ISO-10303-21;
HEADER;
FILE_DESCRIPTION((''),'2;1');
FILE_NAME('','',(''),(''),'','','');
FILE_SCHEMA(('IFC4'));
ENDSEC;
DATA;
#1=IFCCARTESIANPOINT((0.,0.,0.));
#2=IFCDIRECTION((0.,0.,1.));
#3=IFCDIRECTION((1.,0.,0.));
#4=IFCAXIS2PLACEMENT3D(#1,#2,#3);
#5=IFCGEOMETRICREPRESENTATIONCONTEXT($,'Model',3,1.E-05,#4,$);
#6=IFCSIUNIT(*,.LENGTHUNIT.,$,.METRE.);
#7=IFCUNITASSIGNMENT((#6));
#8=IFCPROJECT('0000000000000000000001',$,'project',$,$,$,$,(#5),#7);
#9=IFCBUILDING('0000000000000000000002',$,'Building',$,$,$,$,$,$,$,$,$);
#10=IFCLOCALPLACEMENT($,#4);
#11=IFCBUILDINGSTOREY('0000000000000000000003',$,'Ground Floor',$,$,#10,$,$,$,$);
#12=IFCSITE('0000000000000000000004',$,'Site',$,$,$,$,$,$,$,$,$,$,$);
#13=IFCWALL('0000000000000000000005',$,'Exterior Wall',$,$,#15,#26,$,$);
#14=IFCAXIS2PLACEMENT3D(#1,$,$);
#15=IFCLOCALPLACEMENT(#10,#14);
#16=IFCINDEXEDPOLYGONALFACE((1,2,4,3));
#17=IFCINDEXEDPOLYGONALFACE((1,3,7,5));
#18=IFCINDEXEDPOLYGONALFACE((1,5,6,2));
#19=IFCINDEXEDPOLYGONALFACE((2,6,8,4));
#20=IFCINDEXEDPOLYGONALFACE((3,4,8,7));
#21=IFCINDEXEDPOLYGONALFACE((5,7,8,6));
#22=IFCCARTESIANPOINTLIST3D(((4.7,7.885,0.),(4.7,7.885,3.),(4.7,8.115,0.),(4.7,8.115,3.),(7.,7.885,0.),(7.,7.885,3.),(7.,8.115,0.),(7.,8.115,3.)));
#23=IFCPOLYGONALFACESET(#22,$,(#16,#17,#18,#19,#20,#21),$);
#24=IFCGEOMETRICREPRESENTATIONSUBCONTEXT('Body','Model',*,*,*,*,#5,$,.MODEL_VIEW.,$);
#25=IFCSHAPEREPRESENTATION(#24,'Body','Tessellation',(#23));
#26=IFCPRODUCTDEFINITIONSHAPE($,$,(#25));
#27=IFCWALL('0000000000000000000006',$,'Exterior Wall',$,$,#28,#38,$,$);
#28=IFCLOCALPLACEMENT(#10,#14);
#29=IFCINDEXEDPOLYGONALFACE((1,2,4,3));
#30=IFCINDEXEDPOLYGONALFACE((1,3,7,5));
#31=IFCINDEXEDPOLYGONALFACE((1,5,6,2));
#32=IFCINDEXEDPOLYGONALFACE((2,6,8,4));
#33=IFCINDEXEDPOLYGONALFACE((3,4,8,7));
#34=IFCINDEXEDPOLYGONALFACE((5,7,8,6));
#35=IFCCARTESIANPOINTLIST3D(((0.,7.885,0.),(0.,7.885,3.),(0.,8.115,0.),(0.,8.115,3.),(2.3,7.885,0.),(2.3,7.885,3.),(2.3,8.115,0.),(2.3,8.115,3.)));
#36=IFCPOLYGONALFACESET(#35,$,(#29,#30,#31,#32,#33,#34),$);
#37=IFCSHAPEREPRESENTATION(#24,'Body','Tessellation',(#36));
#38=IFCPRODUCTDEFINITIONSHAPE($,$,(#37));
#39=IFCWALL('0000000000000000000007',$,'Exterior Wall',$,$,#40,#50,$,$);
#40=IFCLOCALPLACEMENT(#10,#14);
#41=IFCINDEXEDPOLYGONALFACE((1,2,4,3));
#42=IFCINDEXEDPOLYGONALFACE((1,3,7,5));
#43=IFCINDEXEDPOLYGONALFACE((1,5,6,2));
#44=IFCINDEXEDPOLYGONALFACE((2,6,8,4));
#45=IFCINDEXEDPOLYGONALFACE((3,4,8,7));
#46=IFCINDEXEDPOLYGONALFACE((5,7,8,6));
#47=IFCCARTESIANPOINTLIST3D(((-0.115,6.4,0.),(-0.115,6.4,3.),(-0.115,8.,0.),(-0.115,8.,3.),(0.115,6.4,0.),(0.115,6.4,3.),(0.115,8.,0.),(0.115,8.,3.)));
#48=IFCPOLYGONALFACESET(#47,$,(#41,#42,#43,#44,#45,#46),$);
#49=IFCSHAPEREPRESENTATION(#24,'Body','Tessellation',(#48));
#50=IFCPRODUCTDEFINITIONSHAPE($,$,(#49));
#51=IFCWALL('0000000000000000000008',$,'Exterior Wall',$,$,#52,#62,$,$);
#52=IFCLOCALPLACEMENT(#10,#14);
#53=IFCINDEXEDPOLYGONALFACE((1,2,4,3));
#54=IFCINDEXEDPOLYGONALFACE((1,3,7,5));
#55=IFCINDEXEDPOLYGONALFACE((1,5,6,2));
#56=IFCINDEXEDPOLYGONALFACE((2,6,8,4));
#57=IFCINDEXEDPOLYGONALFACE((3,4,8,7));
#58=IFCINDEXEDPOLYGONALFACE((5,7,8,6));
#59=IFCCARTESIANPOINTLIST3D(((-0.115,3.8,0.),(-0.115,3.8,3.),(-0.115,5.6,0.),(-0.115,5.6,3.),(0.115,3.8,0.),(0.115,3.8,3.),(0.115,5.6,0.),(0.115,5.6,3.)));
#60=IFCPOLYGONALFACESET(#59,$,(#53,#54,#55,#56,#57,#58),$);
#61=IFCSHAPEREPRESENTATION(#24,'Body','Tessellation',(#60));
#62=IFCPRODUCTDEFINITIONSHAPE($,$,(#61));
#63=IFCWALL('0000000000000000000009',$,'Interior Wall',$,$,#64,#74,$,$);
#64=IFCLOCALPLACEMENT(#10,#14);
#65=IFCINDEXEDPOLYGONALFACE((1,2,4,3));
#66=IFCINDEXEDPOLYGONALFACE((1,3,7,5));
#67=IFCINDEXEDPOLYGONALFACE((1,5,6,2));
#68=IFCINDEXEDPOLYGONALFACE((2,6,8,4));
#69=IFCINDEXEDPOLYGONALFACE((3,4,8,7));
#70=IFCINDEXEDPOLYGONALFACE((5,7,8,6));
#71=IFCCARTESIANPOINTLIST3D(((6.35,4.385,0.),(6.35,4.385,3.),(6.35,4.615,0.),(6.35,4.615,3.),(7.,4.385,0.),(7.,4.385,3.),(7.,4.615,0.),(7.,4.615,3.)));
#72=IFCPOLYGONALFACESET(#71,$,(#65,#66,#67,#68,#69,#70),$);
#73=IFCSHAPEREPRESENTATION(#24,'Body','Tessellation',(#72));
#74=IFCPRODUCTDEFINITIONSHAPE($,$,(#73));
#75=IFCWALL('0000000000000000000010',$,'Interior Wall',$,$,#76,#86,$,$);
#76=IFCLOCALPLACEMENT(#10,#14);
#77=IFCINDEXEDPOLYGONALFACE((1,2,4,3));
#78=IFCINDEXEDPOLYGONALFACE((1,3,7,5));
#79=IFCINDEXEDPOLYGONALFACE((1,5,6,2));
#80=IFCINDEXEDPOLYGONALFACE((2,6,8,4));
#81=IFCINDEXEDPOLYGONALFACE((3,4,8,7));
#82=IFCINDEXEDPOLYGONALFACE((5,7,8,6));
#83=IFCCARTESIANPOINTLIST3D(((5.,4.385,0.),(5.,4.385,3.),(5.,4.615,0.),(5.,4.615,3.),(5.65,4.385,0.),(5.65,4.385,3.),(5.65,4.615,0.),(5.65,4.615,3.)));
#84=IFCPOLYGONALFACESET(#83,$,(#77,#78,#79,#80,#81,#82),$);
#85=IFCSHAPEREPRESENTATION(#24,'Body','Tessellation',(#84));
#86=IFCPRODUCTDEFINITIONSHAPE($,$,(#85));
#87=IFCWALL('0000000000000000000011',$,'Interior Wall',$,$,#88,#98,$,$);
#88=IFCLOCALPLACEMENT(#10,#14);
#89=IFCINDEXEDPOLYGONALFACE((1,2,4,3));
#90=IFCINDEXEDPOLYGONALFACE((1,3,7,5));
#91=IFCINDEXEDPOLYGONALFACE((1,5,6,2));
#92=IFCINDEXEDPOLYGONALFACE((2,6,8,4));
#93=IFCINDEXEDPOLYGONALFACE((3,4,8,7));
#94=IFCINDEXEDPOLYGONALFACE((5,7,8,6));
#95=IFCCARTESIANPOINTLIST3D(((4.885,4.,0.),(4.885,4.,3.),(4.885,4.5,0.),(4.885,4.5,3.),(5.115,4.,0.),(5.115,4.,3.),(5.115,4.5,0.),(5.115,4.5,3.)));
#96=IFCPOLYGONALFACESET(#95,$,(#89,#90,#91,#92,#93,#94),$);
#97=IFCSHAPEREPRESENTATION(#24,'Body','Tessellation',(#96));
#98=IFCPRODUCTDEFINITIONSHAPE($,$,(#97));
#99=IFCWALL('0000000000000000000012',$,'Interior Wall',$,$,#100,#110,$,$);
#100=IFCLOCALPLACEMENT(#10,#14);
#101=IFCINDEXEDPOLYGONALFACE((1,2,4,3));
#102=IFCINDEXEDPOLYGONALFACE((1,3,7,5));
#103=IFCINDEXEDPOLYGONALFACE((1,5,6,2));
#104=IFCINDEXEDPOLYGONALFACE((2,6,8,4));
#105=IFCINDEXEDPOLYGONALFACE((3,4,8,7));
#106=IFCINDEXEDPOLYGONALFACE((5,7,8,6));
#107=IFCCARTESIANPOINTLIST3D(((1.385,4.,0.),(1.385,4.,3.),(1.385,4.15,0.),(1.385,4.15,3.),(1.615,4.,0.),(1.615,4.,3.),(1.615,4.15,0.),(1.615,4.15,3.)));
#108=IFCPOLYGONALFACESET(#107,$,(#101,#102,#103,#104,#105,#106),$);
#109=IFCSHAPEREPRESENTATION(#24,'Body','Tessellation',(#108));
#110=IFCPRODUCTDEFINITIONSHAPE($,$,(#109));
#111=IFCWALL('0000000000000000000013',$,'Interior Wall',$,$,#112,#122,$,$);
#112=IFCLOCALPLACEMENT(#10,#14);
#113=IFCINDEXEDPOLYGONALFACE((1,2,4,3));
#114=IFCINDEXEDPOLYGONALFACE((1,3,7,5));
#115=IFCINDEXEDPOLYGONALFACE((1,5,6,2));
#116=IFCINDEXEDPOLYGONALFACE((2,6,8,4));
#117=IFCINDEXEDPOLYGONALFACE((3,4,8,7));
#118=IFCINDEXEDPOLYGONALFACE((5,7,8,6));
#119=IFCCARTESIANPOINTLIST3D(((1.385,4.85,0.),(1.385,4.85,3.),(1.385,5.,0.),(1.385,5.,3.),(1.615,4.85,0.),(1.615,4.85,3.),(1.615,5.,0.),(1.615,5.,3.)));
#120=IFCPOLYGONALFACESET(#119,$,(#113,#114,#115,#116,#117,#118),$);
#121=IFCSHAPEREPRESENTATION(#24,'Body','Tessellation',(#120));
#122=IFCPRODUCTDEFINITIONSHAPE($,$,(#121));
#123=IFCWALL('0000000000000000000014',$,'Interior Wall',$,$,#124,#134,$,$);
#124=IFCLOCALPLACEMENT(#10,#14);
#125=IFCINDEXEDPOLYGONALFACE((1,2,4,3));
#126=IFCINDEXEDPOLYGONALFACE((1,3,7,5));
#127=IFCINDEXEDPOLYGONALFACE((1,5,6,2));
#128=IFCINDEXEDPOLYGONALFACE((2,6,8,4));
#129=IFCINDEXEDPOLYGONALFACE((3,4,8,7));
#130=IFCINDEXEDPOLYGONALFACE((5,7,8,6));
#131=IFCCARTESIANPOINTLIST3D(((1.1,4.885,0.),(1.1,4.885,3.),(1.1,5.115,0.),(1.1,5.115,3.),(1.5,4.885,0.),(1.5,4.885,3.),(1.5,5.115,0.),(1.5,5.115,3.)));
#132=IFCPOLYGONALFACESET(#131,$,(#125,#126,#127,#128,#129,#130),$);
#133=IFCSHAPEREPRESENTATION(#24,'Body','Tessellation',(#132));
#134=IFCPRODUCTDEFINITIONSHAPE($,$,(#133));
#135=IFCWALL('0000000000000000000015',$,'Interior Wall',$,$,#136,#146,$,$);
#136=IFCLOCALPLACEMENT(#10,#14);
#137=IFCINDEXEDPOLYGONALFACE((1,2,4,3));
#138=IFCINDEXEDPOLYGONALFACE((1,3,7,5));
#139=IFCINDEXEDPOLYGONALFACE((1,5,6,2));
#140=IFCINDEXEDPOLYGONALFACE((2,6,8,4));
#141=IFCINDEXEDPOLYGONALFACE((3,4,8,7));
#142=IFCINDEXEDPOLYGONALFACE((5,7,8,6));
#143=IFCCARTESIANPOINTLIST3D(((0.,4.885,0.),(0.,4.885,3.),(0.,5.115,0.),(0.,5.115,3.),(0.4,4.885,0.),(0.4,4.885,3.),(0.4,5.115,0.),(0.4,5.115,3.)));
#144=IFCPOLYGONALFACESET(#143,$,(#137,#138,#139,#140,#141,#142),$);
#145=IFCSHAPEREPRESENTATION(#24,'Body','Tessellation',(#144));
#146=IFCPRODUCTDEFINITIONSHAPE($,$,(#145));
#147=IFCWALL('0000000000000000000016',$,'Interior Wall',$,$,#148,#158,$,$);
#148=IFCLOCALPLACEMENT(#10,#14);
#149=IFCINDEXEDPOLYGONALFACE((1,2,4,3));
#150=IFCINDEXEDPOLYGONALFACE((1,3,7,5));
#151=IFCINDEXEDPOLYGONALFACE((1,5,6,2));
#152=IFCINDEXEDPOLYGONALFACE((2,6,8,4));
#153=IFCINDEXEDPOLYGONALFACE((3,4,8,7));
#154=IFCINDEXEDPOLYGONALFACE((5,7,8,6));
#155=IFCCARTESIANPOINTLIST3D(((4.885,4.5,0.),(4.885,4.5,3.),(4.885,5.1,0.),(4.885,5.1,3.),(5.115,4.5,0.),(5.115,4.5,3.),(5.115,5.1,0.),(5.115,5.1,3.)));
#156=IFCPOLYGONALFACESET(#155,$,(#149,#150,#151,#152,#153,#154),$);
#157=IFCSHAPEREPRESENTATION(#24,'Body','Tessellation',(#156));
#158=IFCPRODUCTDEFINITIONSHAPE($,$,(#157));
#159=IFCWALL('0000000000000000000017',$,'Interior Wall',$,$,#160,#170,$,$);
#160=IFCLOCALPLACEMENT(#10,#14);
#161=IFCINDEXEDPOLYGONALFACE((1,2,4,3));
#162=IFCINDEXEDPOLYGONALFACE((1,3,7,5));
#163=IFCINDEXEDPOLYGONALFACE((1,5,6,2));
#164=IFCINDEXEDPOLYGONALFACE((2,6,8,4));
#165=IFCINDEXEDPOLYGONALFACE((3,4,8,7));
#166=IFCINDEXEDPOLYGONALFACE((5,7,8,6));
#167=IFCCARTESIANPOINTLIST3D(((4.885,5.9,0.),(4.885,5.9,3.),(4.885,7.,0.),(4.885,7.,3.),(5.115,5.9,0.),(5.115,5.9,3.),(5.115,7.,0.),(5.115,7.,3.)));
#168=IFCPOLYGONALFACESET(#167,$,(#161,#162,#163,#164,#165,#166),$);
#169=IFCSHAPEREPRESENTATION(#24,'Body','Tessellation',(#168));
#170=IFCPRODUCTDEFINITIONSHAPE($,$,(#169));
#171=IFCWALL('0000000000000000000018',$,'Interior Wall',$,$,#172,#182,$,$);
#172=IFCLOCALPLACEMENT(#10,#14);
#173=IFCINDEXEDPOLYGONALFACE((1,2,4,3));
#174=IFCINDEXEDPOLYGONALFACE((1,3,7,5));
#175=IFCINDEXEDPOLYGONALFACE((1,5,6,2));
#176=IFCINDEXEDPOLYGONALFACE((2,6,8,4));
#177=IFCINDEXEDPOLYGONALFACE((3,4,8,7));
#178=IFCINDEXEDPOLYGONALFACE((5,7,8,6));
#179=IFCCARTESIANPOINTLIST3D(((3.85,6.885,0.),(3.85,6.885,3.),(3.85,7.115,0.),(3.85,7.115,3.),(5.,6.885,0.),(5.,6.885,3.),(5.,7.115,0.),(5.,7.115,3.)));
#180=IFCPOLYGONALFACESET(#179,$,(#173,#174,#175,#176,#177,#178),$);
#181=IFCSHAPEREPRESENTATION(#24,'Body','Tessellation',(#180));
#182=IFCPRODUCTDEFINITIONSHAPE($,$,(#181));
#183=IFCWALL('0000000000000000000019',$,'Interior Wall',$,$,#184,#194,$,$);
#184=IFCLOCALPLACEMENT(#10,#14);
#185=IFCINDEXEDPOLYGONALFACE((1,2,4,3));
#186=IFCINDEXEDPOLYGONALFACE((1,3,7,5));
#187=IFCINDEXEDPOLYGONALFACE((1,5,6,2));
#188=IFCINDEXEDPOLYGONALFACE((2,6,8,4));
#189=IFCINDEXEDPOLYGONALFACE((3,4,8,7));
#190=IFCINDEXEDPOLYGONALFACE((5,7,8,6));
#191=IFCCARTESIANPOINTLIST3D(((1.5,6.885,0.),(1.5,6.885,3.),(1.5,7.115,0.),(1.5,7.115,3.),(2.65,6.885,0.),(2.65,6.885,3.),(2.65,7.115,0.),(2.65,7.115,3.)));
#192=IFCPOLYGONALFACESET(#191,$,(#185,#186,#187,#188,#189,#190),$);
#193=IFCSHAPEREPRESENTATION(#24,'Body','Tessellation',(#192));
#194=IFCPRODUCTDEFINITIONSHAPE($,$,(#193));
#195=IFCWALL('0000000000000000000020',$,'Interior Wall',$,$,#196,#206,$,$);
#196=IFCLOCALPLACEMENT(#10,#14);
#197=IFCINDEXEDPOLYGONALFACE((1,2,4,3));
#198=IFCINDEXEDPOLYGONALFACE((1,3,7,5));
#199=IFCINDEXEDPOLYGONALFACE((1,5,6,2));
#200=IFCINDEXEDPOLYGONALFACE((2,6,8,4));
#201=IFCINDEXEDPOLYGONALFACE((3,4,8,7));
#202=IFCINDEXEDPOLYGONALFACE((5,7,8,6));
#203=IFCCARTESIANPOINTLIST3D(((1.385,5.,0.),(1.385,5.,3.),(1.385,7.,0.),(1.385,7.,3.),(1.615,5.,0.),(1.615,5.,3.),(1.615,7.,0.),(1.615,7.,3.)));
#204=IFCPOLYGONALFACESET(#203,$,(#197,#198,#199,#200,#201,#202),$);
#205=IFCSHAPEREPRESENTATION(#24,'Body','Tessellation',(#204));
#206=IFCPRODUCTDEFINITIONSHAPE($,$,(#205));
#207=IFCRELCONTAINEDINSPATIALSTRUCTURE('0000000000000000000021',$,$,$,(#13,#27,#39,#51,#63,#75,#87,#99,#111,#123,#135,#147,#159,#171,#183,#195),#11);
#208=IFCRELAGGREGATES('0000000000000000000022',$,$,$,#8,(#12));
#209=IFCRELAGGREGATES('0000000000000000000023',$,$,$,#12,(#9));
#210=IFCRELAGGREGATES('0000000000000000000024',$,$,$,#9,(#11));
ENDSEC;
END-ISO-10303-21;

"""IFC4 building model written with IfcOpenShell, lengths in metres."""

from ifc_helpers import new_model, si_unit, frame, origin_with_axes, place, context, subcontext, project, spatial, indexed_curve, outline, extrude, element, save


model = new_model("IFC4")

# Units and contexts
model_context = context("Model", 3, precision=1e-05, world=origin_with_axes())
body_context = subcontext(model_context, "Body", "Model", "MODEL_VIEW")
ifc_project = project(units=[si_unit("LENGTHUNIT", "METRE")], contexts=[model_context])

# Site, building, storey
site = spatial("IfcSite", under=ifc_project, Name="Site")
building = spatial("IfcBuilding", under=site, Name="Building")
storey_placement = place(None, origin_with_axes())
storey = spatial("IfcBuildingStorey", under=building, at=storey_placement, Name="Ground Floor")

# Walls
for number, where, z_axis, x_axis, name in (
    (1, (7.0, 8.0, 0.0), (0.0, 0.0, 1.0), (-1.0, 0.0, 0.0), "Exterior Wall"),
    (2, (2.3, 8.0, 0.0), (0.0, 0.0, 1.0), (-1.0, 0.0, 0.0), "Exterior Wall"),
):
    element("IfcWall", number, at=place(storey_placement, frame(where, z_axis=z_axis, x_axis=x_axis)), inside=storey, Name=name, context=body_context, shape_type="SweptSolid", body=[
        extrude(outline(indexed_curve([(0.0, 0.0), (0.0, 0.23), (2.3, 0.23), (2.3, 0.0), (0.0, 0.0)], self_intersect=False)), frame((0.0, -0.115, 0.0), z_axis=(0.0, 0.0, 1.0), x_axis=(1.0, 0.0, 0.0)), (0.0, 0.0, 1.0), 3.0),
    ])
wall_1_placement = place(storey_placement, frame((0.0, 8.0, 0.0), z_axis=(0.0, 0.0, 1.0), x_axis=(0.0, -1.0, 0.0)))
element("IfcWall", 3, at=wall_1_placement, inside=storey, Name="Exterior Wall", context=body_context, shape_type="SweptSolid", body=[
    extrude(outline(indexed_curve([(0.0, 0.0), (0.0, 0.23), (1.6, 0.23), (1.6, 0.0), (0.0, 0.0)], self_intersect=False)), frame((0.0, -0.115, 0.0), z_axis=(0.0, 0.0, 1.0), x_axis=(1.0, 0.0, 0.0)), (0.0, 0.0, 1.0), 3.0),
])
wall_2_placement = place(storey_placement, frame((0.0, 5.6, 0.0), z_axis=(0.0, 0.0, 1.0), x_axis=(0.0, -1.0, 0.0)))
element("IfcWall", 4, at=wall_2_placement, inside=storey, Name="Exterior Wall", context=body_context, shape_type="SweptSolid", body=[
    extrude(outline(indexed_curve([(0.0, 0.0), (0.0, 0.23), (1.8, 0.23), (1.8, 0.0), (0.0, 0.0)], self_intersect=False)), frame((0.0, -0.115, 0.0), z_axis=(0.0, 0.0, 1.0), x_axis=(1.0, 0.0, 0.0)), (0.0, 0.0, 1.0), 3.0),
])
for number, where, z_axis, x_axis, name in (
    (5, (7.0, 4.5, 0.0), (0.0, 0.0, 1.0), (-1.0, 0.0, 0.0), "Interior Wall"),
    (6, (5.65, 4.5, 0.0), (0.0, 0.0, 1.0), (-1.0, 0.0, 0.0), "Interior Wall"),
):
    element("IfcWall", number, at=place(storey_placement, frame(where, z_axis=z_axis, x_axis=x_axis)), inside=storey, Name=name, context=body_context, shape_type="SweptSolid", body=[
        extrude(outline(indexed_curve([(0.0, 0.0), (0.0, 0.23), (0.65, 0.23), (0.65, 0.0), (0.0, 0.0)], self_intersect=False)), frame((0.0, -0.115, 0.0), z_axis=(0.0, 0.0, 1.0), x_axis=(1.0, 0.0, 0.0)), (0.0, 0.0, 1.0), 3.0),
    ])
wall_3_placement = place(storey_placement, frame((5.0, 4.5, 0.0), z_axis=(0.0, 0.0, 1.0), x_axis=(0.0, -1.0, 0.0)))
element("IfcWall", 7, at=wall_3_placement, inside=storey, Name="Interior Wall", context=body_context, shape_type="SweptSolid", body=[
    extrude(outline(indexed_curve([(0.0, 0.0), (0.0, 0.23), (0.5, 0.23), (0.5, 0.0), (0.0, 0.0)], self_intersect=False)), frame((0.0, -0.115, 0.0), z_axis=(0.0, 0.0, 1.0), x_axis=(1.0, 0.0, 0.0)), (0.0, 0.0, 1.0), 3.0),
])
for number, where, z_axis, x_axis, name in (
    (8, (1.5, 4.0, 0.0), (0.0, 0.0, 1.0), (0.0, 1.0, 0.0), "Interior Wall"),
    (9, (1.5, 4.85, 0.0), (0.0, 0.0, 1.0), (0.0, 1.0, 0.0), "Interior Wall"),
):
    element("IfcWall", number, at=place(storey_placement, frame(where, z_axis=z_axis, x_axis=x_axis)), inside=storey, Name=name, context=body_context, shape_type="SweptSolid", body=[
        extrude(outline(indexed_curve([(0.0, 0.0), (0.0, 0.23), (0.15, 0.23), (0.15, 0.0), (0.0, 0.0)], self_intersect=False)), frame((0.0, -0.115, 0.0), z_axis=(0.0, 0.0, 1.0), x_axis=(1.0, 0.0, 0.0)), (0.0, 0.0, 1.0), 3.0),
    ])
for number, where, z_axis, x_axis, name in (
    (10, (1.5, 5.0, 0.0), (0.0, 0.0, 1.0), (-1.0, 0.0, 0.0), "Interior Wall"),
    (11, (0.4, 5.0, 0.0), (0.0, 0.0, 1.0), (-1.0, 0.0, 0.0), "Interior Wall"),
):
    element("IfcWall", number, at=place(storey_placement, frame(where, z_axis=z_axis, x_axis=x_axis)), inside=storey, Name=name, context=body_context, shape_type="SweptSolid", body=[
        extrude(outline(indexed_curve([(0.0, 0.0), (0.0, 0.23), (0.4, 0.23), (0.4, 0.0), (0.0, 0.0)], self_intersect=False)), frame((0.0, -0.115, 0.0), z_axis=(0.0, 0.0, 1.0), x_axis=(1.0, 0.0, 0.0)), (0.0, 0.0, 1.0), 3.0),
    ])
wall_4_placement = place(storey_placement, frame((5.0, 4.5, 0.0), z_axis=(0.0, 0.0, 1.0), x_axis=(0.0, 1.0, 0.0)))
element("IfcWall", 12, at=wall_4_placement, inside=storey, Name="Interior Wall", context=body_context, shape_type="SweptSolid", body=[
    extrude(outline(indexed_curve([(0.0, 0.0), (0.0, 0.23), (0.6, 0.23), (0.6, 0.0), (0.0, 0.0)], self_intersect=False)), frame((0.0, -0.115, 0.0), z_axis=(0.0, 0.0, 1.0), x_axis=(1.0, 0.0, 0.0)), (0.0, 0.0, 1.0), 3.0),
])
wall_5_placement = place(storey_placement, frame((5.0, 5.9, 0.0), z_axis=(0.0, 0.0, 1.0), x_axis=(0.0, 1.0, 0.0)))
element("IfcWall", 13, at=wall_5_placement, inside=storey, Name="Interior Wall", context=body_context, shape_type="SweptSolid", body=[
    extrude(outline(indexed_curve([(0.0, 0.0), (0.0, 0.23), (1.1, 0.23), (1.1, 0.0), (0.0, 0.0)], self_intersect=False)), frame((0.0, -0.115, 0.0), z_axis=(0.0, 0.0, 1.0), x_axis=(1.0, 0.0, 0.0)), (0.0, 0.0, 1.0), 3.0),
])
for number, where, z_axis, x_axis, name in (
    (14, (5.0, 7.0, 0.0), (0.0, 0.0, 1.0), (-1.0, 0.0, 0.0), "Interior Wall"),
    (15, (2.65, 7.0, 0.0), (0.0, 0.0, 1.0), (-1.0, 0.0, 0.0), "Interior Wall"),
):
    element("IfcWall", number, at=place(storey_placement, frame(where, z_axis=z_axis, x_axis=x_axis)), inside=storey, Name=name, context=body_context, shape_type="SweptSolid", body=[
        extrude(outline(indexed_curve([(0.0, 0.0), (0.0, 0.23), (1.15, 0.23), (1.15, 0.0), (0.0, 0.0)], self_intersect=False)), frame((0.0, -0.115, 0.0), z_axis=(0.0, 0.0, 1.0), x_axis=(1.0, 0.0, 0.0)), (0.0, 0.0, 1.0), 3.0),
    ])
wall_6_placement = place(storey_placement, frame((1.5, 7.0, 0.0), z_axis=(0.0, 0.0, 1.0), x_axis=(0.0, -1.0, 0.0)))
element("IfcWall", 16, at=wall_6_placement, inside=storey, Name="Interior Wall", context=body_context, shape_type="SweptSolid", body=[
    extrude(outline(indexed_curve([(0.0, 0.0), (0.0, 0.23), (2.0, 0.23), (2.0, 0.0), (0.0, 0.0)], self_intersect=False)), frame((0.0, -0.115, 0.0), z_axis=(0.0, 0.0, 1.0), x_axis=(1.0, 0.0, 0.0)), (0.0, 0.0, 1.0), 3.0),
])

save(model, "model.ifc")
